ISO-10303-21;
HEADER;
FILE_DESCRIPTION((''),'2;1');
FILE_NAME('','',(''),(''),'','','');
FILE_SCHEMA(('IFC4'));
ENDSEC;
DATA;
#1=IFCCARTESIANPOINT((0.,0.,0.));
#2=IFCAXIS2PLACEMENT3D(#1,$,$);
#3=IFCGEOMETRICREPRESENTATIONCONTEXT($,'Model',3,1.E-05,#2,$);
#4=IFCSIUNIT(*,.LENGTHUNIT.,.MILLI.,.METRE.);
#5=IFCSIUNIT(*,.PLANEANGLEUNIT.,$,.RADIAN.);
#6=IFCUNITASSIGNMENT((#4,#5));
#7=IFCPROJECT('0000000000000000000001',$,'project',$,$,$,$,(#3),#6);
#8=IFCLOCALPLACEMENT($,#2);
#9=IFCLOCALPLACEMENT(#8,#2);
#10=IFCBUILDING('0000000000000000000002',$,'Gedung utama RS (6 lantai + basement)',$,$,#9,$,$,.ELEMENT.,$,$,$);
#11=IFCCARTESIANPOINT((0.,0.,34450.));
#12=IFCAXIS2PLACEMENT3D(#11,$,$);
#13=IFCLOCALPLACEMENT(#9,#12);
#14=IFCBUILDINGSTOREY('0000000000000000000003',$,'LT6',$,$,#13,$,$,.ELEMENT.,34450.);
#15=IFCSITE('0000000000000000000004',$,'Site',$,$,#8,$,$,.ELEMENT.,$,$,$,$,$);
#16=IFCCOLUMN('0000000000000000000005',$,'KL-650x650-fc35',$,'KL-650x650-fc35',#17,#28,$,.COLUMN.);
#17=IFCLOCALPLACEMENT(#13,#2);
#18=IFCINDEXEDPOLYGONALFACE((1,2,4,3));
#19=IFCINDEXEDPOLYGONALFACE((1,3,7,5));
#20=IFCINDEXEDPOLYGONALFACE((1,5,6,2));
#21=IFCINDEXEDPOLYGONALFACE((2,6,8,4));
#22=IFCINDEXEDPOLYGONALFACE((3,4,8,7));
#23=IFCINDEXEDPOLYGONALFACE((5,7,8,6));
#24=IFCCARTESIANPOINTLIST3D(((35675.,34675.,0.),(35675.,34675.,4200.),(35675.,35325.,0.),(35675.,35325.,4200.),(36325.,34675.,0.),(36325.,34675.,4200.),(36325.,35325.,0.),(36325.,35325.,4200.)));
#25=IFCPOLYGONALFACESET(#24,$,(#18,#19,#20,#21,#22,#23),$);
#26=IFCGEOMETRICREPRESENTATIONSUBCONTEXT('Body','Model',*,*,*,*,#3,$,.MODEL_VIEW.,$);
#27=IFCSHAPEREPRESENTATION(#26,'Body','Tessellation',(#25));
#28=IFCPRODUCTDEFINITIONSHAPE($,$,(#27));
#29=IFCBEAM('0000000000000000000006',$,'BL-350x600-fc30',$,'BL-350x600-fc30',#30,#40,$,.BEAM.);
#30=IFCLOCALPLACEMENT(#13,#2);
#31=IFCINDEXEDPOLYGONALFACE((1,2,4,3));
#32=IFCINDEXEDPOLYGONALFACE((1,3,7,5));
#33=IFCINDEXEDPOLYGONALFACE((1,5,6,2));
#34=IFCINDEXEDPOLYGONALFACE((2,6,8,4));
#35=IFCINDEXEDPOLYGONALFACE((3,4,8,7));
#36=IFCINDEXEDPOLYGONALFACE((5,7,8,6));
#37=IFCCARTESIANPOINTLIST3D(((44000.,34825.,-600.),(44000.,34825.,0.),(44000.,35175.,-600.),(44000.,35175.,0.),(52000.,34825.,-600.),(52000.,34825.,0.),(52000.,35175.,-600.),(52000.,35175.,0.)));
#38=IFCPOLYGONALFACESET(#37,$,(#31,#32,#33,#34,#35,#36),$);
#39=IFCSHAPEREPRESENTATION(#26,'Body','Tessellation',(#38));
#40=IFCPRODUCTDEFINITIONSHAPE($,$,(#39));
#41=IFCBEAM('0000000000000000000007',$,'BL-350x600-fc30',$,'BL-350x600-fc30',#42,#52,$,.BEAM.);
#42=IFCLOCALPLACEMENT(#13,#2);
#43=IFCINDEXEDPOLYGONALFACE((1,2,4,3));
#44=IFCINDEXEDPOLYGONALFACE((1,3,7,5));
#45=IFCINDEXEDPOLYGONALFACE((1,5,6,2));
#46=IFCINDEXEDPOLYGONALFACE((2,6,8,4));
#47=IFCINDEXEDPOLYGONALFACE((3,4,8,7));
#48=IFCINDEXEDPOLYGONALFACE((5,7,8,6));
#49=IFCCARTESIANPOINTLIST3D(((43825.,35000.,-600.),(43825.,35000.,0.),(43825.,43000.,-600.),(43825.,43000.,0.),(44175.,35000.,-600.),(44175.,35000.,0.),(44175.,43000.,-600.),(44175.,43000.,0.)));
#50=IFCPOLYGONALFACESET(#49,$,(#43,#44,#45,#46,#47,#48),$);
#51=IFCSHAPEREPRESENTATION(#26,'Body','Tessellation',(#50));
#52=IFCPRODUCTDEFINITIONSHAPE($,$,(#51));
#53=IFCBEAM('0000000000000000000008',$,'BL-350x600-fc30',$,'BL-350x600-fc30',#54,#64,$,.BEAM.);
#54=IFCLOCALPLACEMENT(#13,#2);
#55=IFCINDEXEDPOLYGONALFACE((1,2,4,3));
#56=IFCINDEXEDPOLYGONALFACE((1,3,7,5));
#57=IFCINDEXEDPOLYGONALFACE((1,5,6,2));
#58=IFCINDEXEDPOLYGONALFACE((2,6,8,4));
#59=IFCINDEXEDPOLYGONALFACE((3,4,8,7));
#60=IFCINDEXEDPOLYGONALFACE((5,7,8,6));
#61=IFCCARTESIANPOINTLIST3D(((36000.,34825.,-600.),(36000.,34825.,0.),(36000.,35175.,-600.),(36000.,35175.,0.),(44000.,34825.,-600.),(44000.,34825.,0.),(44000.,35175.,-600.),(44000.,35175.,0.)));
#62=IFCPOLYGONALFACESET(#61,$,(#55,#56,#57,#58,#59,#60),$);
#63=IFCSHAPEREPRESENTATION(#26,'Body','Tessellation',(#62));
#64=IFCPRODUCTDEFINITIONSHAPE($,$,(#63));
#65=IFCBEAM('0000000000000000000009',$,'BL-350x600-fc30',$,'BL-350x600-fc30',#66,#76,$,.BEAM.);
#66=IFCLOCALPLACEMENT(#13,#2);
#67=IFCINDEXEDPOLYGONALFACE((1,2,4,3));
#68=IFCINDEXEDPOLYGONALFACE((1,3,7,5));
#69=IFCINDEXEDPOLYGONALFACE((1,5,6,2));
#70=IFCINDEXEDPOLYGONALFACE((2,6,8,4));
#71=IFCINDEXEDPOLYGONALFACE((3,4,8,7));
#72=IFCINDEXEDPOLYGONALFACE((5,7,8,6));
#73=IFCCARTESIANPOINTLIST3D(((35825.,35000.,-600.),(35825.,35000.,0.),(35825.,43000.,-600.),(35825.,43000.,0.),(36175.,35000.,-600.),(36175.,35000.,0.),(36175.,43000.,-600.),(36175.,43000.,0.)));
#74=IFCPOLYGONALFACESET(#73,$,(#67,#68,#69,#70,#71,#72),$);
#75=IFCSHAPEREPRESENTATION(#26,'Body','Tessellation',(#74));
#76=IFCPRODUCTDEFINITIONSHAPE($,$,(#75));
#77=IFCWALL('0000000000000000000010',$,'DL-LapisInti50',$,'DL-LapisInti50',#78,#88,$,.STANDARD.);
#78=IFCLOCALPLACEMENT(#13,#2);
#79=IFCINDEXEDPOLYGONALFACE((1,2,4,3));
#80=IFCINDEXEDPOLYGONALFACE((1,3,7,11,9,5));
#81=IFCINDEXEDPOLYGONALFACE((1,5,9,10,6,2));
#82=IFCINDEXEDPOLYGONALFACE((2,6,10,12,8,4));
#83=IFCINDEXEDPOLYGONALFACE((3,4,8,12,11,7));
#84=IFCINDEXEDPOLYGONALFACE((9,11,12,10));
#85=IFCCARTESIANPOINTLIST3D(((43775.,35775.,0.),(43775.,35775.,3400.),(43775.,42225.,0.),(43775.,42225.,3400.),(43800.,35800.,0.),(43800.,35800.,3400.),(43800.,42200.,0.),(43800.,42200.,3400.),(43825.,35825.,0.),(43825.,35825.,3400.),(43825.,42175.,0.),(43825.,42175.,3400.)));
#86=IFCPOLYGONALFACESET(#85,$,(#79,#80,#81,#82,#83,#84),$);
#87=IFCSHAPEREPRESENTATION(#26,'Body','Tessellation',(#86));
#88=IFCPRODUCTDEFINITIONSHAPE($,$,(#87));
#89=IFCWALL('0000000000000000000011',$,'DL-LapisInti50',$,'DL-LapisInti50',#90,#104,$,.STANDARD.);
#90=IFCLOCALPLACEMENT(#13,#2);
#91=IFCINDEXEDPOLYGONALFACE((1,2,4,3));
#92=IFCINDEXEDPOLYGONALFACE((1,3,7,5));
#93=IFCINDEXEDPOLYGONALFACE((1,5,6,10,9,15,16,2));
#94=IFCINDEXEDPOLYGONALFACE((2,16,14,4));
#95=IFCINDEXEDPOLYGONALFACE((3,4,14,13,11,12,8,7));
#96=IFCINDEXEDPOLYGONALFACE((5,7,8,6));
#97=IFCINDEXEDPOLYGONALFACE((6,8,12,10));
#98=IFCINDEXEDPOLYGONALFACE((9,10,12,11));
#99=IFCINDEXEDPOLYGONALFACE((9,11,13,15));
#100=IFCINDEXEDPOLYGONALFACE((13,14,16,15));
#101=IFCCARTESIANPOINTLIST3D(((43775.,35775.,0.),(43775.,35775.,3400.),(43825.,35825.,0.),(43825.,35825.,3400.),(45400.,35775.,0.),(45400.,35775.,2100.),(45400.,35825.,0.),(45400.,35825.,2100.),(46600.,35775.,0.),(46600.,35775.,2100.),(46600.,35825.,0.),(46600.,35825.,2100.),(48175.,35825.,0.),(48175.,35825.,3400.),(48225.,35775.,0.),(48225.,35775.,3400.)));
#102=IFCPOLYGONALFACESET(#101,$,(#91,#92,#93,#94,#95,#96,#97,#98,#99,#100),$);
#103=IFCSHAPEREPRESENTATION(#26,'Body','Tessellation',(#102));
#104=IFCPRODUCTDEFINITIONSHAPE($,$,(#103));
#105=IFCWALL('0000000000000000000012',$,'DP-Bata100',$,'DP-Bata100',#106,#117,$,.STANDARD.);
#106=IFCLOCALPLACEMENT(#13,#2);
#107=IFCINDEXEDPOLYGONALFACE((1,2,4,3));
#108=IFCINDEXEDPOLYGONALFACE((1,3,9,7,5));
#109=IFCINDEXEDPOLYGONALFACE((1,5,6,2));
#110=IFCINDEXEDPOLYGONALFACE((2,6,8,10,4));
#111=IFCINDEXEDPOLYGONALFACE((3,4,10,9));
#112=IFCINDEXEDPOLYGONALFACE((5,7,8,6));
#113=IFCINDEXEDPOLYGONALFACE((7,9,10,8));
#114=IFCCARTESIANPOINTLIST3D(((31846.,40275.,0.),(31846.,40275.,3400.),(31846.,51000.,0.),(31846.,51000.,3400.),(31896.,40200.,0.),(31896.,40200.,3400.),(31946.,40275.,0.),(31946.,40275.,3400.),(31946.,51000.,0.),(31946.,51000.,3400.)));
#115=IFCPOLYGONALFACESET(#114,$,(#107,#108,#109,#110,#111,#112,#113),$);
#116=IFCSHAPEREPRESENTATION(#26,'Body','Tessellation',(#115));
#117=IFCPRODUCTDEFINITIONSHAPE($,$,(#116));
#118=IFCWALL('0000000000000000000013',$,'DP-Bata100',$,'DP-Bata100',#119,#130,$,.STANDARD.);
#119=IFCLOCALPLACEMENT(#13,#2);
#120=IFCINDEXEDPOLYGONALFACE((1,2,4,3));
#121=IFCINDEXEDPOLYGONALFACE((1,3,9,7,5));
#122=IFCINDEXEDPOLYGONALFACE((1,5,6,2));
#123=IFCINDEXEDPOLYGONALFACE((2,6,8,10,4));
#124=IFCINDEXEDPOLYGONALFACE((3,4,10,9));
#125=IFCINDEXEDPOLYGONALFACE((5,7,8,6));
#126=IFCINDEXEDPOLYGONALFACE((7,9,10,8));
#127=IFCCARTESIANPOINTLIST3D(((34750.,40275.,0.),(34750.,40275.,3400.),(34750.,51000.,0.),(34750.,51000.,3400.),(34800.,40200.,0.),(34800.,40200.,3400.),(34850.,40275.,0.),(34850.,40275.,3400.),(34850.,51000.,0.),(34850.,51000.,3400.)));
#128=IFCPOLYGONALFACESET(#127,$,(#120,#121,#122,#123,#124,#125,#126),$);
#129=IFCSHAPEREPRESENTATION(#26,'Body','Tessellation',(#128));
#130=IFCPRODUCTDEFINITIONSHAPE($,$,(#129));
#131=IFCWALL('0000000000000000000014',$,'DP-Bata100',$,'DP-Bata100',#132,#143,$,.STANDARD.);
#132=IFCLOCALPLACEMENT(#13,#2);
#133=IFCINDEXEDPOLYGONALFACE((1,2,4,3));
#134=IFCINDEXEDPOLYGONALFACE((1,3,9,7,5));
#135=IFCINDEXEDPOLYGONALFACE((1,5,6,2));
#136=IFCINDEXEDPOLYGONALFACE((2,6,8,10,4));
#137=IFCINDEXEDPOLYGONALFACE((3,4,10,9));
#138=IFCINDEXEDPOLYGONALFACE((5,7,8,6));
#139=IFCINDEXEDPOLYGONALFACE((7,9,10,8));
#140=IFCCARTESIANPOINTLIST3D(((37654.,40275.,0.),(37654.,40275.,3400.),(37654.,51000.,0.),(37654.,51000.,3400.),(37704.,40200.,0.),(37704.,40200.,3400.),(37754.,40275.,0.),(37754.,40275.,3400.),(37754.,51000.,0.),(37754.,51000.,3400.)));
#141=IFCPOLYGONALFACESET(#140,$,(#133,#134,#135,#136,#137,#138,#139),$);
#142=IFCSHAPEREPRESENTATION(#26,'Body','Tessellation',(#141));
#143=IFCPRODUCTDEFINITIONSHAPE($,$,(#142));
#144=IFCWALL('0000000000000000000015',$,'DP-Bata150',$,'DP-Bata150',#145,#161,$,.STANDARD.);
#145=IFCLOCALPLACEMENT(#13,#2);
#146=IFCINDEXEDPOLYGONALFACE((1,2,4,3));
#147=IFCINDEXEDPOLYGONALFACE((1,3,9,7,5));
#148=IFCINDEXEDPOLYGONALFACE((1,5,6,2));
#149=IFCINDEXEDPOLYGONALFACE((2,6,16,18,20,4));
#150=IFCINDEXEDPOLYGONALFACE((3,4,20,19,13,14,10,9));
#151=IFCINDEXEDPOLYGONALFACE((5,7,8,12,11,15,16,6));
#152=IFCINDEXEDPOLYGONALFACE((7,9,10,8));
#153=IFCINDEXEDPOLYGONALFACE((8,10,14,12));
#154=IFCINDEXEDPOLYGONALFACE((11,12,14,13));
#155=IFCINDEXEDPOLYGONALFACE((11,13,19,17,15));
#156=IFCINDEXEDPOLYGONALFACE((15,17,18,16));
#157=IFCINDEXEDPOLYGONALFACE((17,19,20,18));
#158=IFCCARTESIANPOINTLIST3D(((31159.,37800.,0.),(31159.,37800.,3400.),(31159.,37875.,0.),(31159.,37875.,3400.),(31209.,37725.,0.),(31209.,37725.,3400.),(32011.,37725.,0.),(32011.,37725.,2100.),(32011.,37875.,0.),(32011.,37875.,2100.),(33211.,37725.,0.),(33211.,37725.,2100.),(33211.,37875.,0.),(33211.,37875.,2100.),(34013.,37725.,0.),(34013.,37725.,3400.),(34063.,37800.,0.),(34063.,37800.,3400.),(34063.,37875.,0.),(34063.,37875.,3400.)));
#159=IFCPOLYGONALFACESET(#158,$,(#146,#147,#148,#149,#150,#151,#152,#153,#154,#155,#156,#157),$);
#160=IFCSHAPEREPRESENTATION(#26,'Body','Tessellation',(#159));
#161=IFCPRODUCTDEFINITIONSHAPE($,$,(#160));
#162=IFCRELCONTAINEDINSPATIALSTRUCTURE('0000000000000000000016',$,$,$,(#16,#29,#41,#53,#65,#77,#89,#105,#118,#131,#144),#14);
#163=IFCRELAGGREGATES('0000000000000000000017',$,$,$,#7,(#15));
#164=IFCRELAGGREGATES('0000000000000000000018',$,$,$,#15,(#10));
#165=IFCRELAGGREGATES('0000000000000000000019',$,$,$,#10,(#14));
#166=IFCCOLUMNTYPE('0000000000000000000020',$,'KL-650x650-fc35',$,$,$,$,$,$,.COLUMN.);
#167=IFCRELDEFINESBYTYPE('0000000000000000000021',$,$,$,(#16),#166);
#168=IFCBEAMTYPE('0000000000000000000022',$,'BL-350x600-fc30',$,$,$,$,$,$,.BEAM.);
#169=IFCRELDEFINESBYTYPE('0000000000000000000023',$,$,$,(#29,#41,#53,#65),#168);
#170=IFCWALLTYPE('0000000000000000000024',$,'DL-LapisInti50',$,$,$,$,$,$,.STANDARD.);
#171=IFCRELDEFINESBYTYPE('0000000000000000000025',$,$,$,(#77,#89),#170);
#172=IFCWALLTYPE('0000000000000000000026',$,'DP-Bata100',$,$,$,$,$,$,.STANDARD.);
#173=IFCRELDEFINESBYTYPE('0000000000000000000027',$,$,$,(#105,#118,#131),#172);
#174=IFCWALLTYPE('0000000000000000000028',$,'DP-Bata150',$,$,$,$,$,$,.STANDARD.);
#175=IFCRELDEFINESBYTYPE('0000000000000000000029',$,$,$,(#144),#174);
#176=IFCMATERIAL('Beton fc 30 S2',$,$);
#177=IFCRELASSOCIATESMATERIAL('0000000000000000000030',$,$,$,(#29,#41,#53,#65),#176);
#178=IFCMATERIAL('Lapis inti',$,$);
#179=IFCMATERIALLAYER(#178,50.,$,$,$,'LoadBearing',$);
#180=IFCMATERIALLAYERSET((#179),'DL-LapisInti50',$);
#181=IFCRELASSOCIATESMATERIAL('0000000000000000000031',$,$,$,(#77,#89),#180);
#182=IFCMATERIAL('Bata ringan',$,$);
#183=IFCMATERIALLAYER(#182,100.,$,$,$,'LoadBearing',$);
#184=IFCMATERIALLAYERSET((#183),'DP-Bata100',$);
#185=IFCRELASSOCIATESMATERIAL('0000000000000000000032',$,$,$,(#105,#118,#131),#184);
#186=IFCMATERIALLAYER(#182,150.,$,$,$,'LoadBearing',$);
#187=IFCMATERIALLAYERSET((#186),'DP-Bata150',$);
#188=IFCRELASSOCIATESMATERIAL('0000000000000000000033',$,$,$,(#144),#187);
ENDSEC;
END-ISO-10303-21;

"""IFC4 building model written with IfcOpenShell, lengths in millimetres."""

from ifc_helpers import new_model, si_unit, frame, frame_2d, origin, origin_2d, place, context, subcontext, project, spatial, polyline, rectangle, outline, extrude, material, layer, layer_set, layer_usage, material_profile, profile_set, profile_usage, type_object, element, save


model = new_model("IFC4")

# Units and contexts
model_context = context("Model", 3, precision=1e-05, world=origin())
body_context = subcontext(model_context, "Body", "Model", "MODEL_VIEW")
ifc_project = project(units=[si_unit("LENGTHUNIT", "METRE", prefix="MILLI"), si_unit("PLANEANGLEUNIT", "RADIAN")], contexts=[model_context])

# Site, building, storey
site_placement = place(None, origin())
site = spatial("IfcSite", under=ifc_project, at=site_placement, Name="Site", CompositionType="ELEMENT")
building_placement = place(site_placement, origin())
building = spatial("IfcBuilding", under=site, at=building_placement, Name="Gedung utama RS (6 lantai + basement)", CompositionType="ELEMENT")
storey_placement = place(building_placement, frame((0.0, 0.0, 34450.0)))
storey = spatial("IfcBuildingStorey", under=building, at=storey_placement, Name="LT6", CompositionType="ELEMENT", Elevation=34450.0)

# Column
ifc_material_profile_1 = material_profile(None, rectangle(XDim=650.0, YDim=650.0, at=origin_2d()), Name="KL-650x650-fc35")
ifc_profile_set_1 = profile_set([ifc_material_profile_1], Name="KL-650x650-fc35")
ifc_profile_usage_1 = profile_usage(ifc_profile_set_1, cardinal=5)
column_type = type_object("IfcColumnType", Name="KL-650x650-fc35", PredefinedType="COLUMN")
column_placement = place(storey_placement, frame((36000.0, 35000.0, 0.0), z_axis=(0.0, 0.0, 1.0), x_axis=(1.0, 0.0, 0.0)))
element("IfcColumn", 1, at=column_placement, inside=storey, type_object=column_type, material=ifc_profile_usage_1, Name="KL-650x650-fc35", ObjectType="KL-650x650-fc35", PredefinedType="COLUMN", context=body_context, shape_type="SweptSolid", body=[
    extrude(rectangle(XDim=650.0, YDim=650.0, at=origin_2d()), origin(), (0.0, 0.0, 1.0), 4200.0),
])

# Beams
ifc_material_1 = material(Name="Beton fc 30 S2")
ifc_material_profile_2 = material_profile(ifc_material_1, rectangle(XDim=350.0, YDim=600.0, at=origin_2d()), Name="BL-350x600-fc30")
ifc_profile_set_2 = profile_set([ifc_material_profile_2], Name="BL-350x600-fc30")
ifc_profile_usage_2 = profile_usage(ifc_profile_set_2, cardinal=8)
beam_type = type_object("IfcBeamType", Name="BL-350x600-fc30", PredefinedType="BEAM")
beam_1_placement = place(storey_placement, frame((44000.0, 35000.0, -300.0)))
element("IfcBeam", 2, at=beam_1_placement, inside=storey, type_object=beam_type, material=ifc_profile_usage_2, Name="BL-350x600-fc30", ObjectType="BL-350x600-fc30", PredefinedType="BEAM", context=body_context, shape_type="SweptSolid", body=[
    extrude(rectangle(XDim=350.0, YDim=600.0, at=origin_2d()), frame((0.0, 0.0, 0.0), z_axis=(1.0, 0.0, 0.0), x_axis=(0.0, 1.0, 0.0)), (0.0, 0.0, 1.0), 8000.0),
])
beam_2_placement = place(storey_placement, frame((44000.0, 35000.0, -300.0)))
element("IfcBeam", 3, at=beam_2_placement, inside=storey, type_object=beam_type, material=ifc_profile_usage_2, Name="BL-350x600-fc30", ObjectType="BL-350x600-fc30", PredefinedType="BEAM", context=body_context, shape_type="SweptSolid", body=[
    extrude(rectangle(XDim=350.0, YDim=600.0, at=origin_2d()), frame((0.0, 0.0, 0.0), z_axis=(0.0, 1.0, 0.0), x_axis=(-1.0, 0.0, 0.0)), (0.0, 0.0, 1.0), 8000.0),
])
beam_3_placement = place(storey_placement, frame((36000.0, 35000.0, -300.0)))
element("IfcBeam", 4, at=beam_3_placement, inside=storey, type_object=beam_type, material=ifc_profile_usage_2, Name="BL-350x600-fc30", ObjectType="BL-350x600-fc30", PredefinedType="BEAM", context=body_context, shape_type="SweptSolid", body=[
    extrude(rectangle(XDim=350.0, YDim=600.0, at=origin_2d()), frame((0.0, 0.0, 0.0), z_axis=(1.0, 0.0, 0.0), x_axis=(0.0, 1.0, 0.0)), (0.0, 0.0, 1.0), 8000.0),
])
beam_4_placement = place(storey_placement, frame((36000.0, 35000.0, -300.0)))
element("IfcBeam", 5, at=beam_4_placement, inside=storey, type_object=beam_type, material=ifc_profile_usage_2, Name="BL-350x600-fc30", ObjectType="BL-350x600-fc30", PredefinedType="BEAM", context=body_context, shape_type="SweptSolid", body=[
    extrude(rectangle(XDim=350.0, YDim=600.0, at=origin_2d()), frame((0.0, 0.0, 0.0), z_axis=(0.0, 1.0, 0.0), x_axis=(-1.0, 0.0, 0.0)), (0.0, 0.0, 1.0), 8000.0),
])

# Wall
ifc_material_2 = material(Name="Lapis inti")
ifc_layer_1 = layer(ifc_material_2, 50.0, Category="LoadBearing")
ifc_layer_set_1 = layer_set([ifc_layer_1], Name="DL-LapisInti50")
ifc_layer_usage_1 = layer_usage(ifc_layer_set_1, "AXIS2", "NEGATIVE", 25.0)
wall_type_1 = type_object("IfcWallType", Name="DL-LapisInti50", PredefinedType="STANDARD")
wall_1_placement = place(storey_placement, frame((43800.0, 42200.0, 0.0), z_axis=(0.0, 0.0, 1.0), x_axis=(0.0, -1.0, 0.0)))
element("IfcWall", 6, at=wall_1_placement, inside=storey, type_object=wall_type_1, material=ifc_layer_usage_1, Name="DL-LapisInti50", ObjectType="DL-LapisInti50", PredefinedType="STANDARD", context=body_context, shape_type="SweptSolid", body=[
    extrude(outline(polyline([(-25.0, -25.0), (0.0, 0.0), (25.0, 25.0), (6375.0, 25.0), (6400.0, 0.0), (6425.0, -25.0), (-25.0, -25.0)])), origin(), (0.0, 0.0, 1.0), 3400.0),
])

# Wall, opening
wall_2_placement = place(storey_placement, frame((43800.0, 35800.0, 0.0), z_axis=(0.0, 0.0, 1.0), x_axis=(1.0, 0.0, 0.0)))
wall_2 = element("IfcWall", 7, at=wall_2_placement, inside=storey, type_object=wall_type_1, material=ifc_layer_usage_1, Name="DL-LapisInti50", ObjectType="DL-LapisInti50", PredefinedType="STANDARD", context=body_context, shape_type="SweptSolid", body=[
    extrude(outline(polyline([(-25.0, -25.0), (0.0, 0.0), (25.0, 25.0), (4375.0, 25.0), (4400.0, 0.0), (4425.0, -25.0), (-25.0, -25.0)])), origin(), (0.0, 0.0, 1.0), 3400.0),
])
opening_1_placement = place(wall_2_placement, frame((1600.0, 0.0, 0.0), z_axis=(0.0, 0.0, 1.0), x_axis=(1.0, 0.0, 0.0)))
element("IfcOpeningElement", 8, at=opening_1_placement, cuts=wall_2, PredefinedType="OPENING", context=body_context, shape_type="SweptSolid", body=[
    extrude(rectangle(XDim=1200.0, YDim=70.0, at=frame_2d((600.0, 0.0))), origin(), (0.0, 0.0, 1.0), 2100.0),
])

# Walls
ifc_material_3 = material(Name="Bata ringan")
ifc_layer_2 = layer(ifc_material_3, 100.0, Category="LoadBearing")
ifc_layer_set_2 = layer_set([ifc_layer_2], Name="DP-Bata100")
ifc_layer_usage_2 = layer_usage(ifc_layer_set_2, "AXIS2", "NEGATIVE", 50.0)
wall_type_2 = type_object("IfcWallType", Name="DP-Bata100", PredefinedType="STANDARD")
for number, where, z_axis, x_axis, name in (
    (9, (31896.0, 40200.0, 0.0), (0.0, 0.0, 1.0), (0.0, 1.0, 0.0), "DP-Bata100"),
    (10, (34800.0, 40200.0, 0.0), (0.0, 0.0, 1.0), (0.0, 1.0, 0.0), "DP-Bata100"),
    (11, (37704.0, 40200.0, 0.0), (0.0, 0.0, 1.0), (0.0, 1.0, 0.0), "DP-Bata100"),
):
    element("IfcWall", number, at=place(storey_placement, frame(where, z_axis=z_axis, x_axis=x_axis)), inside=storey, type_object=wall_type_2, material=ifc_layer_usage_2, Name=name, ObjectType="DP-Bata100", PredefinedType="STANDARD", context=body_context, shape_type="SweptSolid", body=[
        extrude(outline(polyline([(75.0, -50.0), (0.0, 0.0), (75.0, 50.0), (10800.0, 50.0), (10800.0, -50.0), (75.0, -50.0)])), origin(), (0.0, 0.0, 1.0), 3400.0),
    ])

# Wall, opening
ifc_layer_3 = layer(ifc_material_3, 150.0, Category="LoadBearing")
ifc_layer_set_3 = layer_set([ifc_layer_3], Name="DP-Bata150")
ifc_layer_usage_3 = layer_usage(ifc_layer_set_3, "AXIS2", "NEGATIVE", 75.0)
wall_type_3 = type_object("IfcWallType", Name="DP-Bata150", PredefinedType="STANDARD")
wall_3_placement = place(storey_placement, frame((31159.0, 37800.0, 0.0), z_axis=(0.0, 0.0, 1.0), x_axis=(1.0, 0.0, 0.0)))
wall_3 = element("IfcWall", 12, at=wall_3_placement, inside=storey, type_object=wall_type_3, material=ifc_layer_usage_3, Name="DP-Bata150", ObjectType="DP-Bata150", PredefinedType="STANDARD", context=body_context, shape_type="SweptSolid", body=[
    extrude(outline(polyline([(50.0, -75.0), (0.0, 0.0), (0.0, 75.0), (2904.0, 75.0), (2904.0, 0.0), (2854.0, -75.0), (50.0, -75.0)])), origin(), (0.0, 0.0, 1.0), 3400.0),
])
opening_2_placement = place(wall_3_placement, frame((852.0, 0.0, 0.0), z_axis=(0.0, 0.0, 1.0), x_axis=(1.0, 0.0, 0.0)))
element("IfcOpeningElement", 13, at=opening_2_placement, cuts=wall_3, PredefinedType="OPENING", context=body_context, shape_type="SweptSolid", body=[
    extrude(rectangle(XDim=1200.0, YDim=170.0, at=frame_2d((600.0, 0.0))), origin(), (0.0, 0.0, 1.0), 2100.0),
])

save(model, "model.ifc")
